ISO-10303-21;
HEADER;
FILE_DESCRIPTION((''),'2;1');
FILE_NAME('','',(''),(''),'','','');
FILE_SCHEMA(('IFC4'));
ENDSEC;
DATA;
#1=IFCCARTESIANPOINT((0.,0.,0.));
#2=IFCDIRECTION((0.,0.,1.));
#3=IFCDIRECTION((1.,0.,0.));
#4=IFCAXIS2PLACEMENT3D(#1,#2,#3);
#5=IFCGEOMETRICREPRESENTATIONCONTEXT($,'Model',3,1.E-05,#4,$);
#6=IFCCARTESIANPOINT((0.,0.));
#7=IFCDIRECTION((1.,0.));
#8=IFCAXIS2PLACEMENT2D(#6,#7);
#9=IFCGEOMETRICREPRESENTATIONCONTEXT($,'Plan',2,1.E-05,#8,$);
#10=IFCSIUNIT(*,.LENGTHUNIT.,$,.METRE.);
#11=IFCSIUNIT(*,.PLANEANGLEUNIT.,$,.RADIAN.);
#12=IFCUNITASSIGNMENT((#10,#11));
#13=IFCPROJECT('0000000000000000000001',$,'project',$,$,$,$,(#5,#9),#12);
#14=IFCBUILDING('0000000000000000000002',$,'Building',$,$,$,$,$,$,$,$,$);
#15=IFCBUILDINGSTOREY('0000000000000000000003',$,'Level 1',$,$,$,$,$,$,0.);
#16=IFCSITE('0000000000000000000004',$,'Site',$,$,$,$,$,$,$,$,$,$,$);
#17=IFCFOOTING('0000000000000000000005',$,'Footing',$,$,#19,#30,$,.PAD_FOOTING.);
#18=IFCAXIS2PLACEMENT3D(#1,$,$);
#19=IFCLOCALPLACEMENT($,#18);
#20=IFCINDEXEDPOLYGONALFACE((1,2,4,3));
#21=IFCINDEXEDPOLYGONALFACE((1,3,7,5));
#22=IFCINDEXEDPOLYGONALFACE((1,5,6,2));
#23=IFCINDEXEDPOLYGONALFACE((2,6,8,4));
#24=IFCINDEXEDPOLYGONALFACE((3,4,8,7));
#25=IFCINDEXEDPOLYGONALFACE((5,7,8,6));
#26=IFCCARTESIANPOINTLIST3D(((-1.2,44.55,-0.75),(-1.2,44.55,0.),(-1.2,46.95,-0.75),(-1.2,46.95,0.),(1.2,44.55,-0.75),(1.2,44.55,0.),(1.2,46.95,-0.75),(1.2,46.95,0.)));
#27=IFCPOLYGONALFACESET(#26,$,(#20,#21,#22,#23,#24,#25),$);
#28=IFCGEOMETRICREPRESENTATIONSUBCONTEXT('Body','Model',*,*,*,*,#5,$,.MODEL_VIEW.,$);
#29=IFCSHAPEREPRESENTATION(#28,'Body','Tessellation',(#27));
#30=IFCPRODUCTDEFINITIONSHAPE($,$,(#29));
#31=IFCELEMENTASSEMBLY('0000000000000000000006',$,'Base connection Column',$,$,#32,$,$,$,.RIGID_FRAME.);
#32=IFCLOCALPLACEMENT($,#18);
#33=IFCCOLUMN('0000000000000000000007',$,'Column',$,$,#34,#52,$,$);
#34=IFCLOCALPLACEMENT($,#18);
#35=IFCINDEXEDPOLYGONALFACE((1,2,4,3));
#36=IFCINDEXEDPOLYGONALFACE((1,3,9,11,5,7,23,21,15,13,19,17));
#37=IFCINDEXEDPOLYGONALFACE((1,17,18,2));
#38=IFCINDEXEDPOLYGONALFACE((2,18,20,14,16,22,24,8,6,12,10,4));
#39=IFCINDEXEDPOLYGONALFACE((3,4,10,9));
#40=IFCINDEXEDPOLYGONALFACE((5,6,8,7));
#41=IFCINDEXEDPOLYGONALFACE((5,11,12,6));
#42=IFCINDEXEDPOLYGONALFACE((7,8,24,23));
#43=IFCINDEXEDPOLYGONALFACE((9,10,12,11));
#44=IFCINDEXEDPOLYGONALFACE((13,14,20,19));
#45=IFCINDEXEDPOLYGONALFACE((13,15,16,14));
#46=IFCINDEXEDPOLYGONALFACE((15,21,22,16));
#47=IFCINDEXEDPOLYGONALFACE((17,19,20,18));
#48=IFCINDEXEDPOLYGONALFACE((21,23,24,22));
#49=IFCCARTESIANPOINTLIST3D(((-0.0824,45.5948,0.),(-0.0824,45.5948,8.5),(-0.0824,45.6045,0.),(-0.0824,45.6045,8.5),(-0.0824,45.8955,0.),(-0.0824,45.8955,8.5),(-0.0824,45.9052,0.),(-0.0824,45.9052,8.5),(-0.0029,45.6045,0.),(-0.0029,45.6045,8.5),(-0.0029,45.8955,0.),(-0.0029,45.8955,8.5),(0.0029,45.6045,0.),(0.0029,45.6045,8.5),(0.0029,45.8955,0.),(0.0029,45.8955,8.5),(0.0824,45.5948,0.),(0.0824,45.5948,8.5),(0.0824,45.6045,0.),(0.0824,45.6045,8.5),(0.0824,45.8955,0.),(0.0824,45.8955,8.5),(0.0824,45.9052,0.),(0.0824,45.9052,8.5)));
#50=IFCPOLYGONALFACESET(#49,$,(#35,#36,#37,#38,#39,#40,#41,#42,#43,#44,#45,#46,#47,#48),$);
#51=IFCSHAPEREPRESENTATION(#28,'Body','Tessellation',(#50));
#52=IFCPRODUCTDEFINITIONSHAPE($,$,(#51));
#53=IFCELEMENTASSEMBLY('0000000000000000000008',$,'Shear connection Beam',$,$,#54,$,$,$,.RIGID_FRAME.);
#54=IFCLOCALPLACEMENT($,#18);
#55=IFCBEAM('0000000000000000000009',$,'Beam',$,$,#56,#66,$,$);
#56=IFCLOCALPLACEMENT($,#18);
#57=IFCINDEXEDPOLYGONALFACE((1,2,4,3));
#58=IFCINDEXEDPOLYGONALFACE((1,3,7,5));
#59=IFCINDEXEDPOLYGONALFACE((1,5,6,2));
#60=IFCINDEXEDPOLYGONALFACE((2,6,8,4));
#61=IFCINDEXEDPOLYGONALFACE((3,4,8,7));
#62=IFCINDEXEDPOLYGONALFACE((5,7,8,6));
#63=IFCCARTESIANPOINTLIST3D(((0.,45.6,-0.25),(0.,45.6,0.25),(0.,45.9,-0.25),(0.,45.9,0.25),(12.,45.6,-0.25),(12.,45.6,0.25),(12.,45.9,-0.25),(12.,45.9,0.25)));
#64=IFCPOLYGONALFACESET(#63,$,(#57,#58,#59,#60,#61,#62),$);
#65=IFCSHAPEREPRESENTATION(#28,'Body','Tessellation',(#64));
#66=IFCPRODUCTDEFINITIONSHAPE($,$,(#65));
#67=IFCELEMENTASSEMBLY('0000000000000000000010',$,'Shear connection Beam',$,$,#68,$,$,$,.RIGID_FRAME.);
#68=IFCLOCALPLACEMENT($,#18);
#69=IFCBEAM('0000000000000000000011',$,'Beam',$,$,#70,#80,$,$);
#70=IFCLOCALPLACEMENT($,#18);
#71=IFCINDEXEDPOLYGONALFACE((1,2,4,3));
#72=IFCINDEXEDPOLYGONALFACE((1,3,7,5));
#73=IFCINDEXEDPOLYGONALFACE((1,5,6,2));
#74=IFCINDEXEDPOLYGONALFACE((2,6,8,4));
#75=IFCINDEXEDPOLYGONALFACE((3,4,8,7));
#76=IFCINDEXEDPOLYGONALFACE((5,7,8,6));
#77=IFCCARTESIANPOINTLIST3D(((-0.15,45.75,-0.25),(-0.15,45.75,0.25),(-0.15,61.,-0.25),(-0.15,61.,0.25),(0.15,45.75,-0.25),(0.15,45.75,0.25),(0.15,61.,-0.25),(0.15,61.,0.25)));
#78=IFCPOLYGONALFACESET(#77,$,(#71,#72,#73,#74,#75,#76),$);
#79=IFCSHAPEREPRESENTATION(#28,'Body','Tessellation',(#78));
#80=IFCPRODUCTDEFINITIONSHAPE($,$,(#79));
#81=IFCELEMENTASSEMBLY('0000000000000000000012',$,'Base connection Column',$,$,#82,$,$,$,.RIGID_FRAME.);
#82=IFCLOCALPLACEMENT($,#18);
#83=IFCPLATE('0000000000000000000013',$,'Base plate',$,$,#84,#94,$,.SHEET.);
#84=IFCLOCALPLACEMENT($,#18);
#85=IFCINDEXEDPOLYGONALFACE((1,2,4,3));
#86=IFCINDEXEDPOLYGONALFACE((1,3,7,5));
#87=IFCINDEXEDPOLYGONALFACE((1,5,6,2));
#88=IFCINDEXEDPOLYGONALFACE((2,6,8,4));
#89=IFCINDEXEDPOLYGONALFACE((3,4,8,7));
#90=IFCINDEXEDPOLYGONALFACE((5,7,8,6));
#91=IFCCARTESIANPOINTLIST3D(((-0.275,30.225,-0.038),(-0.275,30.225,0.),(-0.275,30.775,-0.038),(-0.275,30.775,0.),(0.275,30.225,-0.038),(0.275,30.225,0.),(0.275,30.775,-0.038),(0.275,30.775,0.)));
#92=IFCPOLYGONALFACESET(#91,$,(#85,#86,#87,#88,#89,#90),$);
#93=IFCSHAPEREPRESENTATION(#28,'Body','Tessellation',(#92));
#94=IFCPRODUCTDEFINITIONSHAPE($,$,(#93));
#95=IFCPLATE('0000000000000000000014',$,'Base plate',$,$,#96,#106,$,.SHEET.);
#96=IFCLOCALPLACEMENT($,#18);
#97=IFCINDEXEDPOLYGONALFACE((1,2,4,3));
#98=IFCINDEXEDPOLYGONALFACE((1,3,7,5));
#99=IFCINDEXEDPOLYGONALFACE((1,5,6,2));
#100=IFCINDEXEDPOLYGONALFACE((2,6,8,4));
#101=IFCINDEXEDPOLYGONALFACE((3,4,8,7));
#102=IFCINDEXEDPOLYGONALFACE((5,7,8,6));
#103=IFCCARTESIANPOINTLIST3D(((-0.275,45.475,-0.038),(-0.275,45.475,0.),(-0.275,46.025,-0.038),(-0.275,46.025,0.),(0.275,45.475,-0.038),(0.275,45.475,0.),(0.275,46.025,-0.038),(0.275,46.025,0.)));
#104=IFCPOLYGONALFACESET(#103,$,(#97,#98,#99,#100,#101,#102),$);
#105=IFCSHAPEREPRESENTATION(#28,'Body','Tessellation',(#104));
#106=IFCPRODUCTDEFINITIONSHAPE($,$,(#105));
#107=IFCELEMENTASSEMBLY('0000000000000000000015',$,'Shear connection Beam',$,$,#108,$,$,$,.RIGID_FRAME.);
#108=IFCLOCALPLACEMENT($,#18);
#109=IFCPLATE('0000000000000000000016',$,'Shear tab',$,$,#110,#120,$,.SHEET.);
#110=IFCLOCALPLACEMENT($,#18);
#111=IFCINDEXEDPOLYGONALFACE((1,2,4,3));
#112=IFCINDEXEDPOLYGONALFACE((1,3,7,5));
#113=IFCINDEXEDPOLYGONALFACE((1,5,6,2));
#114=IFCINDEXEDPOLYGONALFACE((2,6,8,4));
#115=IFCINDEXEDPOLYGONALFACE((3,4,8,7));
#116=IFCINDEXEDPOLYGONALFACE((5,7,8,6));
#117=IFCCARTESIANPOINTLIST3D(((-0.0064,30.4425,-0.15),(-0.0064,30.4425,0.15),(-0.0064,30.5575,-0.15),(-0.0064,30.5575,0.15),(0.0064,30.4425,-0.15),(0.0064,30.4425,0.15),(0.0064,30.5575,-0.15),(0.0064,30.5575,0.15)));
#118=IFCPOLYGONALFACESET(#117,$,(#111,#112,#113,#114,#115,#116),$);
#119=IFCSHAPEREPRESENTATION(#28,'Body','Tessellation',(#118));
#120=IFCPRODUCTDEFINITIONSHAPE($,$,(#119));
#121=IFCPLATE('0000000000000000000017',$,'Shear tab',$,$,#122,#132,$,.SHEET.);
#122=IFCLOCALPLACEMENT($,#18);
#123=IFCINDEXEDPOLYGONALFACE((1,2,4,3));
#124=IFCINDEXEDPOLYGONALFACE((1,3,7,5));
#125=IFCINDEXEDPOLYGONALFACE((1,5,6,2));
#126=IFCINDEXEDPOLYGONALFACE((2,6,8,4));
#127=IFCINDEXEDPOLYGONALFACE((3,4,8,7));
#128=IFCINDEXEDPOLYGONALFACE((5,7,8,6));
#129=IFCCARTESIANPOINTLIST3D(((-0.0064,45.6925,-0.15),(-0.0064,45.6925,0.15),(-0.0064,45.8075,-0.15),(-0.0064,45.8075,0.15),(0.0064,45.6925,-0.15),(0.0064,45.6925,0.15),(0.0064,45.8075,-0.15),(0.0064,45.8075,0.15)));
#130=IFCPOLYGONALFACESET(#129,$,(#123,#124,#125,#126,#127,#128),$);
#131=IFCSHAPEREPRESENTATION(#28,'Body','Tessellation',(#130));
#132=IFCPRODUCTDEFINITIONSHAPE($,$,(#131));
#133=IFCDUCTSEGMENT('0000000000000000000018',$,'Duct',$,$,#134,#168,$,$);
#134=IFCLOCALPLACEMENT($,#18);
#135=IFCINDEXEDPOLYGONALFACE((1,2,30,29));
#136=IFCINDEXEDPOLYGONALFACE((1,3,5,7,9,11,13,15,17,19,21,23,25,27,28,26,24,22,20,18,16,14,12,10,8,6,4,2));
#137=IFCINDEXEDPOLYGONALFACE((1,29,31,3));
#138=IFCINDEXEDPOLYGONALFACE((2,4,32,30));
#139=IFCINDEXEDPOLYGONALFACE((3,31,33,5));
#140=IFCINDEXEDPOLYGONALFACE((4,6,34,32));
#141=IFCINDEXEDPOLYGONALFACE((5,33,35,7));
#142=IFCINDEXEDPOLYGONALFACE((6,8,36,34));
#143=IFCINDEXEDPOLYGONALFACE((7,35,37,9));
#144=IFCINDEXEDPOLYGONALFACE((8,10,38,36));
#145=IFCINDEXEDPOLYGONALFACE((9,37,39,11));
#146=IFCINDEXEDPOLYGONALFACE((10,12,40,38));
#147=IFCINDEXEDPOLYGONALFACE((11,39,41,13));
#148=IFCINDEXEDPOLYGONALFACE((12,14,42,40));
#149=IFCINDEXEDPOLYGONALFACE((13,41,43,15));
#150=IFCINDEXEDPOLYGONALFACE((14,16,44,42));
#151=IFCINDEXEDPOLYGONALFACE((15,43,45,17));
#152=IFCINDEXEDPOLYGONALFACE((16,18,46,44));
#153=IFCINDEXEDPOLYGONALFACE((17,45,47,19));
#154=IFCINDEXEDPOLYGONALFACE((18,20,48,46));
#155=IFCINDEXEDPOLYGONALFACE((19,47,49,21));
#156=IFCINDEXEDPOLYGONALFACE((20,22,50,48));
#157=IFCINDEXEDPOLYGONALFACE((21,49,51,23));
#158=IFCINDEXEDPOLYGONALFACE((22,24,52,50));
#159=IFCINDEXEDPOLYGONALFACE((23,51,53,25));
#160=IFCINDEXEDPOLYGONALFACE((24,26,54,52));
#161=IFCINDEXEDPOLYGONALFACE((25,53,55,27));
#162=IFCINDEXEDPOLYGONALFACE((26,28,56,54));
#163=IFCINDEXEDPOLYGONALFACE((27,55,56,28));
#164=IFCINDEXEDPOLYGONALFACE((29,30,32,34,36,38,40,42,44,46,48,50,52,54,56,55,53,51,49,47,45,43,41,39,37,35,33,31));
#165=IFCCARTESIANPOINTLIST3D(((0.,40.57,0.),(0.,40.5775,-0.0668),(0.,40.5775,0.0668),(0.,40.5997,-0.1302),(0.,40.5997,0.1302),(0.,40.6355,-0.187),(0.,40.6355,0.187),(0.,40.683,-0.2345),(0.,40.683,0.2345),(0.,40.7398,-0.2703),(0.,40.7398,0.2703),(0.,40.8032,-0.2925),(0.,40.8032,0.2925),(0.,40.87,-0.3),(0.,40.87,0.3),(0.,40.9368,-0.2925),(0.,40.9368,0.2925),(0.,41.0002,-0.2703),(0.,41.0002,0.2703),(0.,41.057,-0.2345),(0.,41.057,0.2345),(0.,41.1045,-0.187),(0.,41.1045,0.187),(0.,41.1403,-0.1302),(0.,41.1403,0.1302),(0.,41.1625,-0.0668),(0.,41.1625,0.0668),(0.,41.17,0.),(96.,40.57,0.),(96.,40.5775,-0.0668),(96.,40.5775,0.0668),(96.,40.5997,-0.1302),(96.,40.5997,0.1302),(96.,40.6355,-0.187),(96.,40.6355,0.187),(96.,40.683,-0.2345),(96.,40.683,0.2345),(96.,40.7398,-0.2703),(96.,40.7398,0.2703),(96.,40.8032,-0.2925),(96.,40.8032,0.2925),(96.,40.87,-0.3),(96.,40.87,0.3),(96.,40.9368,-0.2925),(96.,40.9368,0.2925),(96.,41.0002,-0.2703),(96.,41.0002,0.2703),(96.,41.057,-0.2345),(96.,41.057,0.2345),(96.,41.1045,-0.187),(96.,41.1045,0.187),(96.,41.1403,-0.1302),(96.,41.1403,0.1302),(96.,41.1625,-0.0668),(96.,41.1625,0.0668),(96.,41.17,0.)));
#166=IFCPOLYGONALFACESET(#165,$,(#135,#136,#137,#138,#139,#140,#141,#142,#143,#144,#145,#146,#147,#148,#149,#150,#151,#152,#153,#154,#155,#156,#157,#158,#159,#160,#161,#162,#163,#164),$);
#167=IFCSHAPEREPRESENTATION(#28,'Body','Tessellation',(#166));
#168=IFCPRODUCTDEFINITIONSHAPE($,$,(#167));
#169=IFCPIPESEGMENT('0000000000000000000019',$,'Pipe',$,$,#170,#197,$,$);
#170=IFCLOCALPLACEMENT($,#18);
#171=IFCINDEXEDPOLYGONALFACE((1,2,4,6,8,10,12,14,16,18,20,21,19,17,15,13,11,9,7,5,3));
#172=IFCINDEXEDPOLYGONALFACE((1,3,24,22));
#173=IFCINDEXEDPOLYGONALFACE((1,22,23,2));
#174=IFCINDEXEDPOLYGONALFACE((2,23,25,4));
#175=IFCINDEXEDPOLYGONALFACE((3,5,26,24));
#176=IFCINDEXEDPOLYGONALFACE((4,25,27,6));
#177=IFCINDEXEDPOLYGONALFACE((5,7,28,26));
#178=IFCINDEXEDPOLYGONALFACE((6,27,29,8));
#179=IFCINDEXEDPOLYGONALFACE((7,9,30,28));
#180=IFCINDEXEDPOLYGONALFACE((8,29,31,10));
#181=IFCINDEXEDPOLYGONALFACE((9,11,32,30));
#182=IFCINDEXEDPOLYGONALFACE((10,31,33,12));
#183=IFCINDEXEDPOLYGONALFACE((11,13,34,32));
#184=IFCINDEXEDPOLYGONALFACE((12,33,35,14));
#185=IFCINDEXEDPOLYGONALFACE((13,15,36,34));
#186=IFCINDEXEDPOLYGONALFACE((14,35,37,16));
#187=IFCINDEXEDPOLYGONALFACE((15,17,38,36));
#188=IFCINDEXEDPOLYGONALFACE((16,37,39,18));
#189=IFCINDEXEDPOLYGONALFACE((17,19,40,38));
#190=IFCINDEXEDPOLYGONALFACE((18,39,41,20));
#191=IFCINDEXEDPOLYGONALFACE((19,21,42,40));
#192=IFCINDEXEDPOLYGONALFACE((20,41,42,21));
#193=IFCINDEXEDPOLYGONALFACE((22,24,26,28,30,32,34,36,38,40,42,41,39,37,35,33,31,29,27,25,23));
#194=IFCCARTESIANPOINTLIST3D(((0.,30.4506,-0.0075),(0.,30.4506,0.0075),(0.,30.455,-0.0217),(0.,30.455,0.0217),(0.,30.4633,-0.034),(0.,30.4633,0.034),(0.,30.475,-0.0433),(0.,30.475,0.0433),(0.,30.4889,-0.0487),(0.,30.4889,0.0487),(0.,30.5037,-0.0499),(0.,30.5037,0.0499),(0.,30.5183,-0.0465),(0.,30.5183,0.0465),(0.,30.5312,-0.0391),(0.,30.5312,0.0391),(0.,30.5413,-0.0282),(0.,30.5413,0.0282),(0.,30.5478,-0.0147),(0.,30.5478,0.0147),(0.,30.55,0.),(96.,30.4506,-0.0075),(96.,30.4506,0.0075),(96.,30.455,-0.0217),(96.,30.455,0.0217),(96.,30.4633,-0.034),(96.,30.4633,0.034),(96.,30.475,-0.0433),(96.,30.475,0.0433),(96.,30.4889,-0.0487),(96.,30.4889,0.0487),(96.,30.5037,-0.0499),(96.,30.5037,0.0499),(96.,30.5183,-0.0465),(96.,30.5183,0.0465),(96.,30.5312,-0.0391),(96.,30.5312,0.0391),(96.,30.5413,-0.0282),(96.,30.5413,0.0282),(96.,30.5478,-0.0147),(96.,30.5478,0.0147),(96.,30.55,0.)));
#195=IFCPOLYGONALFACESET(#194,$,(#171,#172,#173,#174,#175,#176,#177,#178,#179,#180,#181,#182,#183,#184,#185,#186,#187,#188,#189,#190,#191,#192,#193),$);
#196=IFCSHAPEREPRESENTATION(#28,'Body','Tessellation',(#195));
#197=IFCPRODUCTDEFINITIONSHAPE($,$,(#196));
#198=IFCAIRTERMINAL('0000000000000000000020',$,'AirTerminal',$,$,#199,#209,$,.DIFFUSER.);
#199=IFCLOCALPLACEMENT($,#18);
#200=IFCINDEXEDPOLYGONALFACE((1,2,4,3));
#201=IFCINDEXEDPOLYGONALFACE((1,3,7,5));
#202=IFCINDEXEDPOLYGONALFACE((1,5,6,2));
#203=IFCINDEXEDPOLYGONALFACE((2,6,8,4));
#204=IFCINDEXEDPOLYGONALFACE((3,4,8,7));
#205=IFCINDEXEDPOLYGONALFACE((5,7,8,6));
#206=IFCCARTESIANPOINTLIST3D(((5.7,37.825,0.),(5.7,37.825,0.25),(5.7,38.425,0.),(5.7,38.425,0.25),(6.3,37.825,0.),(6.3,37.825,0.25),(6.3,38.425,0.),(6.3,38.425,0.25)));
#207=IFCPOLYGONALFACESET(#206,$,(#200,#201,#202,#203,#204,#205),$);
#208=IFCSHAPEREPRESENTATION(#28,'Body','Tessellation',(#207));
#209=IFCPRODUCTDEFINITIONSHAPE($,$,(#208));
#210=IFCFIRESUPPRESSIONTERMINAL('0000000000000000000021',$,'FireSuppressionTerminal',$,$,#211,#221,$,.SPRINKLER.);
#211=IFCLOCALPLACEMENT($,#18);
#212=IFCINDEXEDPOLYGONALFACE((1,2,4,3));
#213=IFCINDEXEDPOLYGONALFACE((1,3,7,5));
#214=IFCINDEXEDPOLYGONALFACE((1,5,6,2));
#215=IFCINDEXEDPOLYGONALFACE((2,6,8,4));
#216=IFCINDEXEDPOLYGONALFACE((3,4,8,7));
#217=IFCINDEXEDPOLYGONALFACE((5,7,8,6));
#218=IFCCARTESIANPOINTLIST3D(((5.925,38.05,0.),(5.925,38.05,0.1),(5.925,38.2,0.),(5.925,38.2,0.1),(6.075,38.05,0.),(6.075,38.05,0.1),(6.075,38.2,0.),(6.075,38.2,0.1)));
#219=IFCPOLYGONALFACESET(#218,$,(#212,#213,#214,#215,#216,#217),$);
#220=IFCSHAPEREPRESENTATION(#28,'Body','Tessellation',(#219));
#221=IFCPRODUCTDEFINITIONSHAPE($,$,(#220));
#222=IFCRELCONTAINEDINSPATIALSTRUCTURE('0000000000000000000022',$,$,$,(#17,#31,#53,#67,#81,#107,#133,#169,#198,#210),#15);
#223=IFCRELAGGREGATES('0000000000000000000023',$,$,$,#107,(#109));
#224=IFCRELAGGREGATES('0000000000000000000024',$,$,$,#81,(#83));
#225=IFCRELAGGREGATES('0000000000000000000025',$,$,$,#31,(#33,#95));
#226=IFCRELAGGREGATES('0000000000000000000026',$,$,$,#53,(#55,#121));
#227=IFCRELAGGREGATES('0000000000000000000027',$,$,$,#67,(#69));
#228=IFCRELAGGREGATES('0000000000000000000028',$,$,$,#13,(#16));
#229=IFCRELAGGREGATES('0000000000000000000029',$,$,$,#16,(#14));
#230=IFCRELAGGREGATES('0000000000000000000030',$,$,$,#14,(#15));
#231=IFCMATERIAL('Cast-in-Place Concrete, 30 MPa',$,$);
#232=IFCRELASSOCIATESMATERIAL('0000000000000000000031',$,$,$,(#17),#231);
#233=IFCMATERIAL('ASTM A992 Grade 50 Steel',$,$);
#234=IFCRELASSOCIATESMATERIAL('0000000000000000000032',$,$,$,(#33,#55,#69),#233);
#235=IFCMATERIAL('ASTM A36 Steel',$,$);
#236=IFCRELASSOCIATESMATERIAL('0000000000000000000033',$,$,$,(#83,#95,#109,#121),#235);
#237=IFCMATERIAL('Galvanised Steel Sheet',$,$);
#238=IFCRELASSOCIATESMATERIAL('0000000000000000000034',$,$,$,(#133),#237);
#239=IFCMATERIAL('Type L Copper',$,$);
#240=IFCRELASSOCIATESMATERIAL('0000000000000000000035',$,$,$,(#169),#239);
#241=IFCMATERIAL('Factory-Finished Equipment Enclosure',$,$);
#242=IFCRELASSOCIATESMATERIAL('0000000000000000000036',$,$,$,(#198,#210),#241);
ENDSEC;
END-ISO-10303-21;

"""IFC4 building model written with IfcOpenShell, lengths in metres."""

from ifc_helpers import new_model, si_unit, frame, origin_with_axes, origin_2d_with_axis, place, context, subcontext, project, spatial, rectangle, circle, i_section, extrude, material, element, aggregate, save


model = new_model("IFC4")

# Units and contexts
model_context = context("Model", 3, precision=1e-05, world=origin_with_axes())
plan_context = context("Plan", 2, precision=1e-05, world=origin_2d_with_axis())
body_context = subcontext(model_context, "Body", "Model", "MODEL_VIEW")
ifc_project = project(units=[si_unit("LENGTHUNIT", "METRE"), si_unit("PLANEANGLEUNIT", "RADIAN")], contexts=[model_context, plan_context])

# Site, building, storey
site = spatial("IfcSite", under=ifc_project, Name="Site")
building = spatial("IfcBuilding", under=site, Name="Building")
storey = spatial("IfcBuildingStorey", under=building, Name="Level 1", Elevation=0.0)

# Footing
ifc_material_1 = material(Name="Cast-in-Place Concrete, 30 MPa")
footing_placement = place(None, frame((0.0, 45.75, -0.75), z_axis=(0.0, 0.0, 1.0), x_axis=(1.0, 0.0, 0.0)))
element("IfcFooting", 1, at=footing_placement, inside=storey, material=ifc_material_1, Name="Footing", PredefinedType="PAD_FOOTING", context=body_context, shape_type="SweptSolid", body=[
    extrude(rectangle(XDim=2.4, YDim=2.4, at=origin_2d_with_axis()), origin_with_axes(), (0.0, 0.0, 1.0), 0.75),
])

# Element assembly, column
assembly_1 = element("IfcElementAssembly", 2, inside=storey, Name="Base connection Column", PredefinedType="RIGID_FRAME")
ifc_material_2 = material(Name="ASTM A992 Grade 50 Steel")
column_placement = place(None, frame((0.0, 45.75, 0.0), z_axis=(0.0, 0.0, 1.0), x_axis=(1.0, 0.0, 0.0)))
column = element("IfcColumn", 3, at=column_placement, material=ifc_material_2, Name="Column", context=body_context, shape_type="SweptSolid", body=[
    extrude(i_section(OverallWidth=0.1648, OverallDepth=0.3104, WebThickness=0.0058, FlangeThickness=0.0097, at=origin_2d_with_axis()), origin_with_axes(), (0.0, 0.0, 1.0), 8.5),
])

# Element assemblies, beams
assembly_2 = element("IfcElementAssembly", 4, inside=storey, Name="Shear connection Beam", PredefinedType="RIGID_FRAME")
beam_1_placement = place(None, frame((0.0, 45.75, 0.0), z_axis=(1.0, 0.0, 0.0), x_axis=(0.0, 1.0, 0.0)))
beam_1 = element("IfcBeam", 5, at=beam_1_placement, material=ifc_material_2, Name="Beam", context=body_context, shape_type="SweptSolid", body=[
    extrude(rectangle(XDim=0.3, YDim=0.5, at=origin_2d_with_axis()), origin_with_axes(), (0.0, 0.0, 1.0), 12.0),
])
assembly_3 = element("IfcElementAssembly", 6, inside=storey, Name="Shear connection Beam", PredefinedType="RIGID_FRAME")
beam_2_placement = place(None, frame((0.0, 45.75, 0.0), z_axis=(0.0, 1.0, 0.0), x_axis=(-1.0, 0.0, 0.0)))
beam_2 = element("IfcBeam", 7, at=beam_2_placement, material=ifc_material_2, Name="Beam", context=body_context, shape_type="SweptSolid", body=[
    extrude(rectangle(XDim=0.3, YDim=0.5, at=origin_2d_with_axis()), origin_with_axes(), (0.0, 0.0, 1.0), 15.25),
])

# Element assembly, plate
assembly_4 = element("IfcElementAssembly", 8, inside=storey, Name="Base connection Column", PredefinedType="RIGID_FRAME")
ifc_material_3 = material(Name="ASTM A36 Steel")
plate_1_placement = place(None, frame((0.0, 30.5, -0.038), z_axis=(0.0, 0.0, 1.0), x_axis=(1.0, 0.0, 0.0)))
plate_1 = element("IfcPlate", 9, at=plate_1_placement, material=ifc_material_3, Name="Base plate", PredefinedType="SHEET", context=body_context, shape_type="SweptSolid", body=[
    extrude(rectangle(XDim=0.55, YDim=0.55, at=origin_2d_with_axis()), origin_with_axes(), (0.0, 0.0, 1.0), 0.038),
])

# Plate
plate_2_placement = place(None, frame((0.0, 45.75, -0.038), z_axis=(0.0, 0.0, 1.0), x_axis=(1.0, 0.0, 0.0)))
plate_2 = element("IfcPlate", 10, at=plate_2_placement, material=ifc_material_3, Name="Base plate", PredefinedType="SHEET", context=body_context, shape_type="SweptSolid", body=[
    extrude(rectangle(XDim=0.55, YDim=0.55, at=origin_2d_with_axis()), origin_with_axes(), (0.0, 0.0, 1.0), 0.038),
])

# Element assembly, plate
assembly_5 = element("IfcElementAssembly", 11, inside=storey, Name="Shear connection Beam", PredefinedType="RIGID_FRAME")
plate_3_placement = place(None, frame((0.0, 30.5, -0.15), z_axis=(0.0, 0.0, 1.0), x_axis=(1.0, 0.0, 0.0)))
plate_3 = element("IfcPlate", 12, at=plate_3_placement, material=ifc_material_3, Name="Shear tab", PredefinedType="SHEET", context=body_context, shape_type="SweptSolid", body=[
    extrude(rectangle(XDim=0.0127, YDim=0.115, at=origin_2d_with_axis()), origin_with_axes(), (0.0, 0.0, 1.0), 0.3),
])
aggregate(assembly_5, [plate_3])

# Plate
plate_4_placement = place(None, frame((0.0, 45.75, -0.15), z_axis=(0.0, 0.0, 1.0), x_axis=(1.0, 0.0, 0.0)))
plate_4 = element("IfcPlate", 13, at=plate_4_placement, material=ifc_material_3, Name="Shear tab", PredefinedType="SHEET", context=body_context, shape_type="SweptSolid", body=[
    extrude(rectangle(XDim=0.0127, YDim=0.115, at=origin_2d_with_axis()), origin_with_axes(), (0.0, 0.0, 1.0), 0.3),
])

# Duct segment
ifc_material_4 = material(Name="Galvanised Steel Sheet")
duct_segment_placement = place(None, frame((0.0, 40.87, 0.0), z_axis=(1.0, 0.0, 0.0), x_axis=(0.0, 1.0, 0.0)))
element("IfcDuctSegment", 14, at=duct_segment_placement, inside=storey, material=ifc_material_4, Name="Duct", context=body_context, shape_type="SweptSolid", body=[
    extrude(circle(Radius=0.3, at=origin_2d_with_axis()), origin_with_axes(), (0.0, 0.0, 1.0), 96.0),
])

# Pipe segment
ifc_material_5 = material(Name="Type L Copper")
pipe_segment_placement = place(None, frame((0.0, 30.5, 0.0), z_axis=(1.0, 0.0, 0.0), x_axis=(0.0, 1.0, 0.0)))
element("IfcPipeSegment", 15, at=pipe_segment_placement, inside=storey, material=ifc_material_5, Name="Pipe", context=body_context, shape_type="SweptSolid", body=[
    extrude(circle(Radius=0.05, at=origin_2d_with_axis()), origin_with_axes(), (0.0, 0.0, 1.0), 96.0),
])

# Air terminal
ifc_material_6 = material(Name="Factory-Finished Equipment Enclosure")
air_terminal_placement = place(None, frame((6.0, 38.125, 0.0), z_axis=(0.0, 0.0, 1.0), x_axis=(1.0, 0.0, 0.0)))
element("IfcAirTerminal", 16, at=air_terminal_placement, inside=storey, material=ifc_material_6, Name="AirTerminal", PredefinedType="DIFFUSER", context=body_context, shape_type="SweptSolid", body=[
    extrude(rectangle(XDim=0.6, YDim=0.6, at=origin_2d_with_axis()), origin_with_axes(), (0.0, 0.0, 1.0), 0.25),
])

# Fire suppression terminal
fire_suppression_terminal_placement = place(None, frame((6.0, 38.125, 0.0), z_axis=(0.0, 0.0, 1.0), x_axis=(1.0, 0.0, 0.0)))
element("IfcFireSuppressionTerminal", 17, at=fire_suppression_terminal_placement, inside=storey, material=ifc_material_6, Name="FireSuppressionTerminal", PredefinedType="SPRINKLER", context=body_context, shape_type="SweptSolid", body=[
    extrude(rectangle(XDim=0.15, YDim=0.15, at=origin_2d_with_axis()), origin_with_axes(), (0.0, 0.0, 1.0), 0.1),
])

aggregate(assembly_4, [plate_1])
aggregate(assembly_1, [column, plate_2])

aggregate(assembly_2, [beam_1, plate_4])
aggregate(assembly_3, [beam_2])

save(model, "model.ifc")
